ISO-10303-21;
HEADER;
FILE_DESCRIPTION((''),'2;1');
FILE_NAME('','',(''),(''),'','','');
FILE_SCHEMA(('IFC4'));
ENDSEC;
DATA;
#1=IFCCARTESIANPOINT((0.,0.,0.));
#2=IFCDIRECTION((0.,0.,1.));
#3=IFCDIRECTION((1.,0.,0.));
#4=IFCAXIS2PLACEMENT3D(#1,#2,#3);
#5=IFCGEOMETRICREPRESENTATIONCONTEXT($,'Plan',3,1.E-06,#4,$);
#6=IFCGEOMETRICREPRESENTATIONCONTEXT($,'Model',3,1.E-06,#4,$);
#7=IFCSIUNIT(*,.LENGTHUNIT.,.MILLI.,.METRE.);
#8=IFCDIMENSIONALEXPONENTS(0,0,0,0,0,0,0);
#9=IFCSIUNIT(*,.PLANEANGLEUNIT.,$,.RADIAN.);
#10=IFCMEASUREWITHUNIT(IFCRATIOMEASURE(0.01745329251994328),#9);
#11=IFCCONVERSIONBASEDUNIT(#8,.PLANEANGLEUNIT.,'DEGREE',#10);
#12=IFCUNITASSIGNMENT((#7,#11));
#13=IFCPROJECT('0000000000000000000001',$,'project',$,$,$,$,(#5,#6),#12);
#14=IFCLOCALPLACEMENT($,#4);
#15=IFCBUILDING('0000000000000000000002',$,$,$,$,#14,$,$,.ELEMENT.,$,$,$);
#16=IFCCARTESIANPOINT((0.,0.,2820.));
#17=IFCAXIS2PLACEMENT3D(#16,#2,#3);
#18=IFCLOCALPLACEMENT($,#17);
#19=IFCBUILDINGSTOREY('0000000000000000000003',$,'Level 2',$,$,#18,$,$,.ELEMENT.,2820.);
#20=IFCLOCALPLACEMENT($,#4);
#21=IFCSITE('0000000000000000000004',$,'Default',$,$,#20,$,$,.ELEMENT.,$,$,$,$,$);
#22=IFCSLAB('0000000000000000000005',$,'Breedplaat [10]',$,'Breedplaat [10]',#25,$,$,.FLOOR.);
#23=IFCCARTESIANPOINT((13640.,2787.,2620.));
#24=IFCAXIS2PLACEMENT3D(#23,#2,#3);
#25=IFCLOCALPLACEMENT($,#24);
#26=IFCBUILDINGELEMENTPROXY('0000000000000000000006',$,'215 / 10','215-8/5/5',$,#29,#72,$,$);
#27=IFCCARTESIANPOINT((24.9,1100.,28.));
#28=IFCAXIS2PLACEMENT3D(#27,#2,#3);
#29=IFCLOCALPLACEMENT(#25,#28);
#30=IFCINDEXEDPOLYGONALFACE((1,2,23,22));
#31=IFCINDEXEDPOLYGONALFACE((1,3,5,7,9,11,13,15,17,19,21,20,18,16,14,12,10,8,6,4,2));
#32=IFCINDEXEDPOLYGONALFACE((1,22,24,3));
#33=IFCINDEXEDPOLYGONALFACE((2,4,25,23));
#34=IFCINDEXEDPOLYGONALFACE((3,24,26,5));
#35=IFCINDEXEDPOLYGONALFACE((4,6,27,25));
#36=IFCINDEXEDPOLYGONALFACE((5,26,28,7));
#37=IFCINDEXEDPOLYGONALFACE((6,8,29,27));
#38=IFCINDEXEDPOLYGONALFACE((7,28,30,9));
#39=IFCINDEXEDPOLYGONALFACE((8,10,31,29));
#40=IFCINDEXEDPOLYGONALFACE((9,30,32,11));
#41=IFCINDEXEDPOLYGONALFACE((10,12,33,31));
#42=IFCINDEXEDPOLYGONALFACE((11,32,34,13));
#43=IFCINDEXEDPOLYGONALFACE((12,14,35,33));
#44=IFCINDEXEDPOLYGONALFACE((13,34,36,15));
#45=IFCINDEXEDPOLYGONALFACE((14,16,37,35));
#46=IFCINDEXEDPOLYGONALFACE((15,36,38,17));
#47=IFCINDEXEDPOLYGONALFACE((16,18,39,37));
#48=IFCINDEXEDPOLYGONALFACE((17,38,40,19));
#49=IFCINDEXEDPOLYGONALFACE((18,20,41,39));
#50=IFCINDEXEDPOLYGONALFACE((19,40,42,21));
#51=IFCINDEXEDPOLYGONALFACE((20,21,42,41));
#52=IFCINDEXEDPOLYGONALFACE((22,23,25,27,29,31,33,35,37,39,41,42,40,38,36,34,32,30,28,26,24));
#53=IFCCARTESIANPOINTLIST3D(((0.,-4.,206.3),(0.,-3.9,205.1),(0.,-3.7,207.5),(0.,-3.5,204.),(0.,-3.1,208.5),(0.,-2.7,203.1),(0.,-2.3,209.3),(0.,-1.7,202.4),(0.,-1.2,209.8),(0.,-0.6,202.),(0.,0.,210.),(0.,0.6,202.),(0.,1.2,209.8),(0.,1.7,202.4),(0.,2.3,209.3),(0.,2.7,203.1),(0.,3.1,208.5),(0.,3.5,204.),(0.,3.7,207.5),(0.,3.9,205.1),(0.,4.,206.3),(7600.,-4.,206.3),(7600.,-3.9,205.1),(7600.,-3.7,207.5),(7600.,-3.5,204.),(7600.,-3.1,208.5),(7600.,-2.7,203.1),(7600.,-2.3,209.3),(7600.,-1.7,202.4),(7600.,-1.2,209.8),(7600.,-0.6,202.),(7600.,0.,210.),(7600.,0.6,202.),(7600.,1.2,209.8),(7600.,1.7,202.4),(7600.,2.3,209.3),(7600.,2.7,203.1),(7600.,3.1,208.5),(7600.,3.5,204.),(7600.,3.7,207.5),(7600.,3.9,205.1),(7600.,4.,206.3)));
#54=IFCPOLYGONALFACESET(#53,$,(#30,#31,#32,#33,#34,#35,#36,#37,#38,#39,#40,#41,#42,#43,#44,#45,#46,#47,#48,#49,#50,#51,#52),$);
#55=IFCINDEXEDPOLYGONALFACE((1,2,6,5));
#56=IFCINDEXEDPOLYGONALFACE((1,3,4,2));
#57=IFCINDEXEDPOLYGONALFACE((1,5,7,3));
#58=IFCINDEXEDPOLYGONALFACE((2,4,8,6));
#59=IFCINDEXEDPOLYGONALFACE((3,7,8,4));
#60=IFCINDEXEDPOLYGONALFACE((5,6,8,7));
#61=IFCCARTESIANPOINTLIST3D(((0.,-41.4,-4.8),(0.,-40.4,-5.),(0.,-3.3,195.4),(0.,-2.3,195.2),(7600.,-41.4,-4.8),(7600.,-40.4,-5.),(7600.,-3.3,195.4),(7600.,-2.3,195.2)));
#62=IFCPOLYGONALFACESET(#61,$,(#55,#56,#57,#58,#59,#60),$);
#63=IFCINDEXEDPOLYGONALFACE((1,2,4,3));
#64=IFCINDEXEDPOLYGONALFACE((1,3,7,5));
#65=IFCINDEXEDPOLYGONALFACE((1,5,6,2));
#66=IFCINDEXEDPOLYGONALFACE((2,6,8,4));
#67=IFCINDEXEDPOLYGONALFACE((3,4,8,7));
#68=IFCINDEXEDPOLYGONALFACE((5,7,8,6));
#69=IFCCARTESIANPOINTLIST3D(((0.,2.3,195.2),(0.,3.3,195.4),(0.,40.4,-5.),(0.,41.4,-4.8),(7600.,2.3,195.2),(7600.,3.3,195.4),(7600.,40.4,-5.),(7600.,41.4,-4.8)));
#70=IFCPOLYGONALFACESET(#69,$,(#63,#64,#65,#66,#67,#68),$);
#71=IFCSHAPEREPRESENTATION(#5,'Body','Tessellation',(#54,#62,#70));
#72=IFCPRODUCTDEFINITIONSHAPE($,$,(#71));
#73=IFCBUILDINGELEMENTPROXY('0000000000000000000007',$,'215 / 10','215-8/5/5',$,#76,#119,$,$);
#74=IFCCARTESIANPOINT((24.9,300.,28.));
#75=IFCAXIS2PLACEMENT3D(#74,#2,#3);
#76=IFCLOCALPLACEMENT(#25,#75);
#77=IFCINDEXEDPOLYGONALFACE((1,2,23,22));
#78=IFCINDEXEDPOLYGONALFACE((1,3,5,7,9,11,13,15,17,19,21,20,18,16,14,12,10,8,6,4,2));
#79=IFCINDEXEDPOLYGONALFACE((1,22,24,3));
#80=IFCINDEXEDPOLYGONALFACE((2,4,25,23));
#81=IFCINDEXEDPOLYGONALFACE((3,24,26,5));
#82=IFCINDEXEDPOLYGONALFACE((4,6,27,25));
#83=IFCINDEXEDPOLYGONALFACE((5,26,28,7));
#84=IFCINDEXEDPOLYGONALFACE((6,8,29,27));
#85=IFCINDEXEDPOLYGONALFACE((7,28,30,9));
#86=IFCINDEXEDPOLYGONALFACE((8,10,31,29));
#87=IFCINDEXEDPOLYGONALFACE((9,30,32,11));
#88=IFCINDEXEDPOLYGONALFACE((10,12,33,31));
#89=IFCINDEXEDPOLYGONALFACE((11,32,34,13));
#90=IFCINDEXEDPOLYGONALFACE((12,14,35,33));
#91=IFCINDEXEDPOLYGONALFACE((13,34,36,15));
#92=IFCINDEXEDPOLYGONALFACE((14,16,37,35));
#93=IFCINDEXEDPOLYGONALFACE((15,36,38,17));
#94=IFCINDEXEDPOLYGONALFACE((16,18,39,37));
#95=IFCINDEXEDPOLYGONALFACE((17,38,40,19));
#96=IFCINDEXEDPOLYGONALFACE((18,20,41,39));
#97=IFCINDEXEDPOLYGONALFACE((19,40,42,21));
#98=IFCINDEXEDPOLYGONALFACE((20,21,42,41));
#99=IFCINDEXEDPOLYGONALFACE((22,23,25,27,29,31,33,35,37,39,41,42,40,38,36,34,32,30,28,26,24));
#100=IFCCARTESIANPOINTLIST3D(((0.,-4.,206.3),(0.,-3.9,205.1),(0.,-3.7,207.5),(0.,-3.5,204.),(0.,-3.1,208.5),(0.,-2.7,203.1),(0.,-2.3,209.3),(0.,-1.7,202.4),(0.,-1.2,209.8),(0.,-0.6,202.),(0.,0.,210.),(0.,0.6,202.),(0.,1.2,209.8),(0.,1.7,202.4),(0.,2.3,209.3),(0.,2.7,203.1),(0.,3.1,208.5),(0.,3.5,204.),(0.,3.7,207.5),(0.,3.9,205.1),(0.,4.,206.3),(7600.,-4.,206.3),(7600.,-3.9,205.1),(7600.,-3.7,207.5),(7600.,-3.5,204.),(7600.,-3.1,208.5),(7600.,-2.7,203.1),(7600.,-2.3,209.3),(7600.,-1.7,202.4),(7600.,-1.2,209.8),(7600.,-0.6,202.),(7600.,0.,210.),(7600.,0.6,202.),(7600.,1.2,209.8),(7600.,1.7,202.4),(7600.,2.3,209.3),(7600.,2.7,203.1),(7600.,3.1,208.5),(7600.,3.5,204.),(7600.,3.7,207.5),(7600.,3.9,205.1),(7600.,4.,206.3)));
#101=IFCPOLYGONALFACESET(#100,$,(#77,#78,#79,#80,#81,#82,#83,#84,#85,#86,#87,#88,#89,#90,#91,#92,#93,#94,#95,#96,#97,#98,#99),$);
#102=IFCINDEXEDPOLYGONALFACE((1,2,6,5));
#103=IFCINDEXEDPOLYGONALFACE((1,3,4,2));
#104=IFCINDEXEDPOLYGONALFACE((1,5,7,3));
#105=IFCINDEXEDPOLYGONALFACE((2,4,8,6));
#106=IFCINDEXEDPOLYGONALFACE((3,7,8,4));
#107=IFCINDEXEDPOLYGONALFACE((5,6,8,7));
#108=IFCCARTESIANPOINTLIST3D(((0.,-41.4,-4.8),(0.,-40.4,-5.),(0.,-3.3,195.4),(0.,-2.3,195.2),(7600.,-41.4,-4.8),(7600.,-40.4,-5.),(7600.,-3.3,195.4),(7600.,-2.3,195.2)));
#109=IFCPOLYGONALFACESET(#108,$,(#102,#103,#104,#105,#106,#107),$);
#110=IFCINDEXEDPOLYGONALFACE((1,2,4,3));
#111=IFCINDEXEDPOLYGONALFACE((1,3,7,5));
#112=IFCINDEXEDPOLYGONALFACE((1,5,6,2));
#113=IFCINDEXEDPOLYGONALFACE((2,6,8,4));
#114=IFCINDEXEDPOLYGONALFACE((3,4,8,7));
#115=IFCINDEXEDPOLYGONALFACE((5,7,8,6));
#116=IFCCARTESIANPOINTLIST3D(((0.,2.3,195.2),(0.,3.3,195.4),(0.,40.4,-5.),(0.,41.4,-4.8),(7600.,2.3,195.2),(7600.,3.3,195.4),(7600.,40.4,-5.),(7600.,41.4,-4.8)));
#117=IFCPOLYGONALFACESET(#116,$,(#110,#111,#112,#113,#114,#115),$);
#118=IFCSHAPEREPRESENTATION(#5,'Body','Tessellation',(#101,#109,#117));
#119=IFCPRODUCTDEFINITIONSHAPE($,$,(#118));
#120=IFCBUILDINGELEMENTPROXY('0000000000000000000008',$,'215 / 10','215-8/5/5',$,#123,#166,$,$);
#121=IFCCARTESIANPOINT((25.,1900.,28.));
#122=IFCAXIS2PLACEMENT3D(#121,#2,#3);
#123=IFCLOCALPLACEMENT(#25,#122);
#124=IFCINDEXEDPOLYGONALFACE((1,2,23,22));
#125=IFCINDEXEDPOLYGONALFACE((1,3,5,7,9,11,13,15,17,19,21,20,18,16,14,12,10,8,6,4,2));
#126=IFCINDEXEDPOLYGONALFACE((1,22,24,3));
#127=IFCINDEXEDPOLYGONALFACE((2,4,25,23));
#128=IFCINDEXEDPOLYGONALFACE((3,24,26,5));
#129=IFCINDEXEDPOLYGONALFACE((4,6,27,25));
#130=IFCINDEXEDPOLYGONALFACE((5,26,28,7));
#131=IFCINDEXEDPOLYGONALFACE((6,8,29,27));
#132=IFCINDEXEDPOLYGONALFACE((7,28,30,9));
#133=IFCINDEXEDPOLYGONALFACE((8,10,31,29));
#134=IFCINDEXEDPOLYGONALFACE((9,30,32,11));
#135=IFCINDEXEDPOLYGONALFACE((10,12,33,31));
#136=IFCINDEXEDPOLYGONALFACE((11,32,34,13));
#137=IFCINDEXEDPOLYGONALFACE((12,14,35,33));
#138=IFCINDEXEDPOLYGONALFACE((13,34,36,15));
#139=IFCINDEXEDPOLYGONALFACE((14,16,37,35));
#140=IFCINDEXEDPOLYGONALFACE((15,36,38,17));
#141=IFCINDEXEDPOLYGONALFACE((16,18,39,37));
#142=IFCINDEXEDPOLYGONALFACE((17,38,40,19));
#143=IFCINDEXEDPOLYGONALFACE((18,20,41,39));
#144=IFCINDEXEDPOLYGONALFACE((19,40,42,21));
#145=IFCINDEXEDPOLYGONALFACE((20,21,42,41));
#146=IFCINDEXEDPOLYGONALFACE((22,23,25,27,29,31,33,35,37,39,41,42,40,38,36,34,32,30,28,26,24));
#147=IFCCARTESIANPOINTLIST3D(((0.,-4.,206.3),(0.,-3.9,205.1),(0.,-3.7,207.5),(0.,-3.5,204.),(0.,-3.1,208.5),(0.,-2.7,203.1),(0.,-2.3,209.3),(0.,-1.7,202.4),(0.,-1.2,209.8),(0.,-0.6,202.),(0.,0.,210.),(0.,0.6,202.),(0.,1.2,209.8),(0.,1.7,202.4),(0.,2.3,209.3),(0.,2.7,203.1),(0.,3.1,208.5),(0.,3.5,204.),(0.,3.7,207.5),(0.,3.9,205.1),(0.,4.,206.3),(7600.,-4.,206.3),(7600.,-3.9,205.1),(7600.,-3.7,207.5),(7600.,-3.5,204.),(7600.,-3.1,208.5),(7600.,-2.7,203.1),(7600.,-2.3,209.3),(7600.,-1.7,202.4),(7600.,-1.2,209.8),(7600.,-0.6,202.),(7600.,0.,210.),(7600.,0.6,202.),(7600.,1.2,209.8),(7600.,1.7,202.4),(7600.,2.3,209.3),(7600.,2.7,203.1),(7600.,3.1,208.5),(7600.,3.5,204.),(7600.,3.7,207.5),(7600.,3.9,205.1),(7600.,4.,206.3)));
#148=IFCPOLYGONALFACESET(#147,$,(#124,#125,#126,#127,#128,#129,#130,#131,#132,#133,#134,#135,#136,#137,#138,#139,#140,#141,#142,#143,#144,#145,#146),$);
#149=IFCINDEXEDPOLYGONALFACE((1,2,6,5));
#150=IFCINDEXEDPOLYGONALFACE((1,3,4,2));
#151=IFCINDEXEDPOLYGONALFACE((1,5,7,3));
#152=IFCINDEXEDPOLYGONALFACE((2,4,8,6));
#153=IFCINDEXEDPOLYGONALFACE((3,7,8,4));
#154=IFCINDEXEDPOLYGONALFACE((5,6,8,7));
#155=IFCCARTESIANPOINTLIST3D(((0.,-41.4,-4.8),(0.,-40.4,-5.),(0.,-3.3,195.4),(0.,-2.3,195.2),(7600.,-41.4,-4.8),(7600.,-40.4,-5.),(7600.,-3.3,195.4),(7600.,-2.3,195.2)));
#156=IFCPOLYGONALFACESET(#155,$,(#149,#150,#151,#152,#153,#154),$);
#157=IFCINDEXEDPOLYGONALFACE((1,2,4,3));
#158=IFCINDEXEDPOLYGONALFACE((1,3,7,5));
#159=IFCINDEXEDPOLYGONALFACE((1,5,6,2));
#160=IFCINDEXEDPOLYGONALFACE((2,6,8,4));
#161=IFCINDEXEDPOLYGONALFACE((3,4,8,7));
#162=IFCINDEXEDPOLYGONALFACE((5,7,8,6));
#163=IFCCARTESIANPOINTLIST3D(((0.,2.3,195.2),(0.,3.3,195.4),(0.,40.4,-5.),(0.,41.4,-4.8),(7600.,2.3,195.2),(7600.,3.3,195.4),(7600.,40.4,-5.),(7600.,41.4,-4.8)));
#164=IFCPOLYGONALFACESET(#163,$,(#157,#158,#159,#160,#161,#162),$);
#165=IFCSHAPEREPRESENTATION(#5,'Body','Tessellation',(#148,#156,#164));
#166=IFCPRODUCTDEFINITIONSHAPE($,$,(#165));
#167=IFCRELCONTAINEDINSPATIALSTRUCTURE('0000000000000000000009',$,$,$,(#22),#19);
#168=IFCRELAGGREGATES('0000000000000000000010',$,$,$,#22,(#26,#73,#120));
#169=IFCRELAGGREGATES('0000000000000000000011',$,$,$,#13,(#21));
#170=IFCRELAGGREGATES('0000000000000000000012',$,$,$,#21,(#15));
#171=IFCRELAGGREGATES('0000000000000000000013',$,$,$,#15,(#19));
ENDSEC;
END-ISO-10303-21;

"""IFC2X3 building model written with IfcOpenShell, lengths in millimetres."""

from ifc_helpers import new_model, entity, si_unit, converted_unit, frame, origin_with_axes, origin_2d_with_axis, place, context, project, spatial, rectangle, circle, extrude, element, aggregate, save


model = new_model("IFC2X3")

# Units and contexts
plan_context = context("Plan", 3, precision=1e-06, world=origin_with_axes())
model_context = context("Model", 3, precision=1e-06, world=origin_with_axes())
ifc_project = project(units=[si_unit("LENGTHUNIT", "METRE", prefix="MILLI"), converted_unit("PLANEANGLEUNIT", "DEGREE", entity("IfcRatioMeasure", 0.01745329251994328), si_unit("PLANEANGLEUNIT", "RADIAN"), dimensions=[0, 0, 0, 0, 0, 0, 0])], contexts=[plan_context, model_context])

# Site, building, storey
site_placement = place(None, origin_with_axes())
site = spatial("IfcSite", under=ifc_project, at=site_placement, Name="Default", CompositionType="ELEMENT")
building_placement = place(None, origin_with_axes())
building = spatial("IfcBuilding", under=site, at=building_placement, CompositionType="ELEMENT")
storey_placement = place(None, frame((0.0, 0.0, 2820.0), z_axis=(0.0, 0.0, 1.0), x_axis=(1.0, 0.0, 0.0)))
storey = spatial("IfcBuildingStorey", under=building, at=storey_placement, Name="Level 2", CompositionType="ELEMENT", Elevation=2820.0)

# Slab, building element proxies
slab_1_placement = place(None, frame((13640.0, 2787.0, 2620.0), z_axis=(0.0, 0.0, 1.0), x_axis=(1.0, 0.0, 0.0)))
slab_1 = element("IfcSlab", 1, at=slab_1_placement, inside=storey, Name="Breedplaat [10]", ObjectType="Breedplaat [10]", PredefinedType="FLOOR")
proxy_1_placement = place(slab_1_placement, frame((24.9, 1100.0, 28.0), z_axis=(0.0, 0.0, 1.0), x_axis=(1.0, 0.0, 0.0)))
proxy_1 = element("IfcBuildingElementProxy", 2, at=proxy_1_placement, Name="215 / 10", Description="215-8/5/5", context=plan_context, shape_type="SweptSolid", body=[
    extrude(circle(Radius=4.0, at=origin_2d_with_axis()), frame((0.0, 0.0, 206.0), z_axis=(1.0, 0.0, 0.0), x_axis=(0.0, 0.0, 1.0)), (0.0, 0.0, 1.0), 7600.0),
    extrude(rectangle(XDim=203.8, YDim=1.0, at=origin_2d_with_axis()), frame((0.0, -21.9, 95.2), z_axis=(1.0, 0.0, 0.0), x_axis=(0.0, 0.187112, 0.982339)), (0.0, 0.0, 1.0), 7600.0),
    extrude(rectangle(XDim=203.8, YDim=1.0, at=origin_2d_with_axis()), frame((0.0, 21.9, 95.2), z_axis=(1.0, 0.0, 0.0), x_axis=(0.0, -0.187112, 0.982339)), (0.0, 0.0, 1.0), 7600.0),
])
proxy_2_placement = place(slab_1_placement, frame((24.9, 300.0, 28.0), z_axis=(0.0, 0.0, 1.0), x_axis=(1.0, 0.0, 0.0)))
proxy_2 = element("IfcBuildingElementProxy", 3, at=proxy_2_placement, Name="215 / 10", Description="215-8/5/5", context=plan_context, shape_type="SweptSolid", body=[
    extrude(circle(Radius=4.0, at=origin_2d_with_axis()), frame((0.0, 0.0, 206.0), z_axis=(1.0, 0.0, 0.0), x_axis=(0.0, 0.0, 1.0)), (0.0, 0.0, 1.0), 7600.0),
    extrude(rectangle(XDim=203.8, YDim=1.0, at=origin_2d_with_axis()), frame((0.0, -21.9, 95.2), z_axis=(1.0, 0.0, 0.0), x_axis=(0.0, 0.187112, 0.982339)), (0.0, 0.0, 1.0), 7600.0),
    extrude(rectangle(XDim=203.8, YDim=1.0, at=origin_2d_with_axis()), frame((0.0, 21.9, 95.2), z_axis=(1.0, 0.0, 0.0), x_axis=(0.0, -0.187112, 0.982339)), (0.0, 0.0, 1.0), 7600.0),
])
proxy_3_placement = place(slab_1_placement, frame((25.0, 1900.0, 28.0), z_axis=(0.0, 0.0, 1.0), x_axis=(1.0, 0.0, 0.0)))
proxy_3 = element("IfcBuildingElementProxy", 4, at=proxy_3_placement, Name="215 / 10", Description="215-8/5/5", context=plan_context, shape_type="SweptSolid", body=[
    extrude(circle(Radius=4.0, at=origin_2d_with_axis()), frame((0.0, 0.0, 206.0), z_axis=(1.0, 0.0, 0.0), x_axis=(0.0, 0.0, 1.0)), (0.0, 0.0, 1.0), 7600.0),
    extrude(rectangle(XDim=203.8, YDim=1.0, at=origin_2d_with_axis()), frame((0.0, -21.9, 95.2), z_axis=(1.0, 0.0, 0.0), x_axis=(0.0, 0.187112, 0.982339)), (0.0, 0.0, 1.0), 7600.0),
    extrude(rectangle(XDim=203.8, YDim=1.0, at=origin_2d_with_axis()), frame((0.0, 21.9, 95.2), z_axis=(1.0, 0.0, 0.0), x_axis=(0.0, -0.187112, 0.982339)), (0.0, 0.0, 1.0), 7600.0),
])
aggregate(slab_1, [proxy_1, proxy_2, proxy_3])

save(model, "model.ifc")
